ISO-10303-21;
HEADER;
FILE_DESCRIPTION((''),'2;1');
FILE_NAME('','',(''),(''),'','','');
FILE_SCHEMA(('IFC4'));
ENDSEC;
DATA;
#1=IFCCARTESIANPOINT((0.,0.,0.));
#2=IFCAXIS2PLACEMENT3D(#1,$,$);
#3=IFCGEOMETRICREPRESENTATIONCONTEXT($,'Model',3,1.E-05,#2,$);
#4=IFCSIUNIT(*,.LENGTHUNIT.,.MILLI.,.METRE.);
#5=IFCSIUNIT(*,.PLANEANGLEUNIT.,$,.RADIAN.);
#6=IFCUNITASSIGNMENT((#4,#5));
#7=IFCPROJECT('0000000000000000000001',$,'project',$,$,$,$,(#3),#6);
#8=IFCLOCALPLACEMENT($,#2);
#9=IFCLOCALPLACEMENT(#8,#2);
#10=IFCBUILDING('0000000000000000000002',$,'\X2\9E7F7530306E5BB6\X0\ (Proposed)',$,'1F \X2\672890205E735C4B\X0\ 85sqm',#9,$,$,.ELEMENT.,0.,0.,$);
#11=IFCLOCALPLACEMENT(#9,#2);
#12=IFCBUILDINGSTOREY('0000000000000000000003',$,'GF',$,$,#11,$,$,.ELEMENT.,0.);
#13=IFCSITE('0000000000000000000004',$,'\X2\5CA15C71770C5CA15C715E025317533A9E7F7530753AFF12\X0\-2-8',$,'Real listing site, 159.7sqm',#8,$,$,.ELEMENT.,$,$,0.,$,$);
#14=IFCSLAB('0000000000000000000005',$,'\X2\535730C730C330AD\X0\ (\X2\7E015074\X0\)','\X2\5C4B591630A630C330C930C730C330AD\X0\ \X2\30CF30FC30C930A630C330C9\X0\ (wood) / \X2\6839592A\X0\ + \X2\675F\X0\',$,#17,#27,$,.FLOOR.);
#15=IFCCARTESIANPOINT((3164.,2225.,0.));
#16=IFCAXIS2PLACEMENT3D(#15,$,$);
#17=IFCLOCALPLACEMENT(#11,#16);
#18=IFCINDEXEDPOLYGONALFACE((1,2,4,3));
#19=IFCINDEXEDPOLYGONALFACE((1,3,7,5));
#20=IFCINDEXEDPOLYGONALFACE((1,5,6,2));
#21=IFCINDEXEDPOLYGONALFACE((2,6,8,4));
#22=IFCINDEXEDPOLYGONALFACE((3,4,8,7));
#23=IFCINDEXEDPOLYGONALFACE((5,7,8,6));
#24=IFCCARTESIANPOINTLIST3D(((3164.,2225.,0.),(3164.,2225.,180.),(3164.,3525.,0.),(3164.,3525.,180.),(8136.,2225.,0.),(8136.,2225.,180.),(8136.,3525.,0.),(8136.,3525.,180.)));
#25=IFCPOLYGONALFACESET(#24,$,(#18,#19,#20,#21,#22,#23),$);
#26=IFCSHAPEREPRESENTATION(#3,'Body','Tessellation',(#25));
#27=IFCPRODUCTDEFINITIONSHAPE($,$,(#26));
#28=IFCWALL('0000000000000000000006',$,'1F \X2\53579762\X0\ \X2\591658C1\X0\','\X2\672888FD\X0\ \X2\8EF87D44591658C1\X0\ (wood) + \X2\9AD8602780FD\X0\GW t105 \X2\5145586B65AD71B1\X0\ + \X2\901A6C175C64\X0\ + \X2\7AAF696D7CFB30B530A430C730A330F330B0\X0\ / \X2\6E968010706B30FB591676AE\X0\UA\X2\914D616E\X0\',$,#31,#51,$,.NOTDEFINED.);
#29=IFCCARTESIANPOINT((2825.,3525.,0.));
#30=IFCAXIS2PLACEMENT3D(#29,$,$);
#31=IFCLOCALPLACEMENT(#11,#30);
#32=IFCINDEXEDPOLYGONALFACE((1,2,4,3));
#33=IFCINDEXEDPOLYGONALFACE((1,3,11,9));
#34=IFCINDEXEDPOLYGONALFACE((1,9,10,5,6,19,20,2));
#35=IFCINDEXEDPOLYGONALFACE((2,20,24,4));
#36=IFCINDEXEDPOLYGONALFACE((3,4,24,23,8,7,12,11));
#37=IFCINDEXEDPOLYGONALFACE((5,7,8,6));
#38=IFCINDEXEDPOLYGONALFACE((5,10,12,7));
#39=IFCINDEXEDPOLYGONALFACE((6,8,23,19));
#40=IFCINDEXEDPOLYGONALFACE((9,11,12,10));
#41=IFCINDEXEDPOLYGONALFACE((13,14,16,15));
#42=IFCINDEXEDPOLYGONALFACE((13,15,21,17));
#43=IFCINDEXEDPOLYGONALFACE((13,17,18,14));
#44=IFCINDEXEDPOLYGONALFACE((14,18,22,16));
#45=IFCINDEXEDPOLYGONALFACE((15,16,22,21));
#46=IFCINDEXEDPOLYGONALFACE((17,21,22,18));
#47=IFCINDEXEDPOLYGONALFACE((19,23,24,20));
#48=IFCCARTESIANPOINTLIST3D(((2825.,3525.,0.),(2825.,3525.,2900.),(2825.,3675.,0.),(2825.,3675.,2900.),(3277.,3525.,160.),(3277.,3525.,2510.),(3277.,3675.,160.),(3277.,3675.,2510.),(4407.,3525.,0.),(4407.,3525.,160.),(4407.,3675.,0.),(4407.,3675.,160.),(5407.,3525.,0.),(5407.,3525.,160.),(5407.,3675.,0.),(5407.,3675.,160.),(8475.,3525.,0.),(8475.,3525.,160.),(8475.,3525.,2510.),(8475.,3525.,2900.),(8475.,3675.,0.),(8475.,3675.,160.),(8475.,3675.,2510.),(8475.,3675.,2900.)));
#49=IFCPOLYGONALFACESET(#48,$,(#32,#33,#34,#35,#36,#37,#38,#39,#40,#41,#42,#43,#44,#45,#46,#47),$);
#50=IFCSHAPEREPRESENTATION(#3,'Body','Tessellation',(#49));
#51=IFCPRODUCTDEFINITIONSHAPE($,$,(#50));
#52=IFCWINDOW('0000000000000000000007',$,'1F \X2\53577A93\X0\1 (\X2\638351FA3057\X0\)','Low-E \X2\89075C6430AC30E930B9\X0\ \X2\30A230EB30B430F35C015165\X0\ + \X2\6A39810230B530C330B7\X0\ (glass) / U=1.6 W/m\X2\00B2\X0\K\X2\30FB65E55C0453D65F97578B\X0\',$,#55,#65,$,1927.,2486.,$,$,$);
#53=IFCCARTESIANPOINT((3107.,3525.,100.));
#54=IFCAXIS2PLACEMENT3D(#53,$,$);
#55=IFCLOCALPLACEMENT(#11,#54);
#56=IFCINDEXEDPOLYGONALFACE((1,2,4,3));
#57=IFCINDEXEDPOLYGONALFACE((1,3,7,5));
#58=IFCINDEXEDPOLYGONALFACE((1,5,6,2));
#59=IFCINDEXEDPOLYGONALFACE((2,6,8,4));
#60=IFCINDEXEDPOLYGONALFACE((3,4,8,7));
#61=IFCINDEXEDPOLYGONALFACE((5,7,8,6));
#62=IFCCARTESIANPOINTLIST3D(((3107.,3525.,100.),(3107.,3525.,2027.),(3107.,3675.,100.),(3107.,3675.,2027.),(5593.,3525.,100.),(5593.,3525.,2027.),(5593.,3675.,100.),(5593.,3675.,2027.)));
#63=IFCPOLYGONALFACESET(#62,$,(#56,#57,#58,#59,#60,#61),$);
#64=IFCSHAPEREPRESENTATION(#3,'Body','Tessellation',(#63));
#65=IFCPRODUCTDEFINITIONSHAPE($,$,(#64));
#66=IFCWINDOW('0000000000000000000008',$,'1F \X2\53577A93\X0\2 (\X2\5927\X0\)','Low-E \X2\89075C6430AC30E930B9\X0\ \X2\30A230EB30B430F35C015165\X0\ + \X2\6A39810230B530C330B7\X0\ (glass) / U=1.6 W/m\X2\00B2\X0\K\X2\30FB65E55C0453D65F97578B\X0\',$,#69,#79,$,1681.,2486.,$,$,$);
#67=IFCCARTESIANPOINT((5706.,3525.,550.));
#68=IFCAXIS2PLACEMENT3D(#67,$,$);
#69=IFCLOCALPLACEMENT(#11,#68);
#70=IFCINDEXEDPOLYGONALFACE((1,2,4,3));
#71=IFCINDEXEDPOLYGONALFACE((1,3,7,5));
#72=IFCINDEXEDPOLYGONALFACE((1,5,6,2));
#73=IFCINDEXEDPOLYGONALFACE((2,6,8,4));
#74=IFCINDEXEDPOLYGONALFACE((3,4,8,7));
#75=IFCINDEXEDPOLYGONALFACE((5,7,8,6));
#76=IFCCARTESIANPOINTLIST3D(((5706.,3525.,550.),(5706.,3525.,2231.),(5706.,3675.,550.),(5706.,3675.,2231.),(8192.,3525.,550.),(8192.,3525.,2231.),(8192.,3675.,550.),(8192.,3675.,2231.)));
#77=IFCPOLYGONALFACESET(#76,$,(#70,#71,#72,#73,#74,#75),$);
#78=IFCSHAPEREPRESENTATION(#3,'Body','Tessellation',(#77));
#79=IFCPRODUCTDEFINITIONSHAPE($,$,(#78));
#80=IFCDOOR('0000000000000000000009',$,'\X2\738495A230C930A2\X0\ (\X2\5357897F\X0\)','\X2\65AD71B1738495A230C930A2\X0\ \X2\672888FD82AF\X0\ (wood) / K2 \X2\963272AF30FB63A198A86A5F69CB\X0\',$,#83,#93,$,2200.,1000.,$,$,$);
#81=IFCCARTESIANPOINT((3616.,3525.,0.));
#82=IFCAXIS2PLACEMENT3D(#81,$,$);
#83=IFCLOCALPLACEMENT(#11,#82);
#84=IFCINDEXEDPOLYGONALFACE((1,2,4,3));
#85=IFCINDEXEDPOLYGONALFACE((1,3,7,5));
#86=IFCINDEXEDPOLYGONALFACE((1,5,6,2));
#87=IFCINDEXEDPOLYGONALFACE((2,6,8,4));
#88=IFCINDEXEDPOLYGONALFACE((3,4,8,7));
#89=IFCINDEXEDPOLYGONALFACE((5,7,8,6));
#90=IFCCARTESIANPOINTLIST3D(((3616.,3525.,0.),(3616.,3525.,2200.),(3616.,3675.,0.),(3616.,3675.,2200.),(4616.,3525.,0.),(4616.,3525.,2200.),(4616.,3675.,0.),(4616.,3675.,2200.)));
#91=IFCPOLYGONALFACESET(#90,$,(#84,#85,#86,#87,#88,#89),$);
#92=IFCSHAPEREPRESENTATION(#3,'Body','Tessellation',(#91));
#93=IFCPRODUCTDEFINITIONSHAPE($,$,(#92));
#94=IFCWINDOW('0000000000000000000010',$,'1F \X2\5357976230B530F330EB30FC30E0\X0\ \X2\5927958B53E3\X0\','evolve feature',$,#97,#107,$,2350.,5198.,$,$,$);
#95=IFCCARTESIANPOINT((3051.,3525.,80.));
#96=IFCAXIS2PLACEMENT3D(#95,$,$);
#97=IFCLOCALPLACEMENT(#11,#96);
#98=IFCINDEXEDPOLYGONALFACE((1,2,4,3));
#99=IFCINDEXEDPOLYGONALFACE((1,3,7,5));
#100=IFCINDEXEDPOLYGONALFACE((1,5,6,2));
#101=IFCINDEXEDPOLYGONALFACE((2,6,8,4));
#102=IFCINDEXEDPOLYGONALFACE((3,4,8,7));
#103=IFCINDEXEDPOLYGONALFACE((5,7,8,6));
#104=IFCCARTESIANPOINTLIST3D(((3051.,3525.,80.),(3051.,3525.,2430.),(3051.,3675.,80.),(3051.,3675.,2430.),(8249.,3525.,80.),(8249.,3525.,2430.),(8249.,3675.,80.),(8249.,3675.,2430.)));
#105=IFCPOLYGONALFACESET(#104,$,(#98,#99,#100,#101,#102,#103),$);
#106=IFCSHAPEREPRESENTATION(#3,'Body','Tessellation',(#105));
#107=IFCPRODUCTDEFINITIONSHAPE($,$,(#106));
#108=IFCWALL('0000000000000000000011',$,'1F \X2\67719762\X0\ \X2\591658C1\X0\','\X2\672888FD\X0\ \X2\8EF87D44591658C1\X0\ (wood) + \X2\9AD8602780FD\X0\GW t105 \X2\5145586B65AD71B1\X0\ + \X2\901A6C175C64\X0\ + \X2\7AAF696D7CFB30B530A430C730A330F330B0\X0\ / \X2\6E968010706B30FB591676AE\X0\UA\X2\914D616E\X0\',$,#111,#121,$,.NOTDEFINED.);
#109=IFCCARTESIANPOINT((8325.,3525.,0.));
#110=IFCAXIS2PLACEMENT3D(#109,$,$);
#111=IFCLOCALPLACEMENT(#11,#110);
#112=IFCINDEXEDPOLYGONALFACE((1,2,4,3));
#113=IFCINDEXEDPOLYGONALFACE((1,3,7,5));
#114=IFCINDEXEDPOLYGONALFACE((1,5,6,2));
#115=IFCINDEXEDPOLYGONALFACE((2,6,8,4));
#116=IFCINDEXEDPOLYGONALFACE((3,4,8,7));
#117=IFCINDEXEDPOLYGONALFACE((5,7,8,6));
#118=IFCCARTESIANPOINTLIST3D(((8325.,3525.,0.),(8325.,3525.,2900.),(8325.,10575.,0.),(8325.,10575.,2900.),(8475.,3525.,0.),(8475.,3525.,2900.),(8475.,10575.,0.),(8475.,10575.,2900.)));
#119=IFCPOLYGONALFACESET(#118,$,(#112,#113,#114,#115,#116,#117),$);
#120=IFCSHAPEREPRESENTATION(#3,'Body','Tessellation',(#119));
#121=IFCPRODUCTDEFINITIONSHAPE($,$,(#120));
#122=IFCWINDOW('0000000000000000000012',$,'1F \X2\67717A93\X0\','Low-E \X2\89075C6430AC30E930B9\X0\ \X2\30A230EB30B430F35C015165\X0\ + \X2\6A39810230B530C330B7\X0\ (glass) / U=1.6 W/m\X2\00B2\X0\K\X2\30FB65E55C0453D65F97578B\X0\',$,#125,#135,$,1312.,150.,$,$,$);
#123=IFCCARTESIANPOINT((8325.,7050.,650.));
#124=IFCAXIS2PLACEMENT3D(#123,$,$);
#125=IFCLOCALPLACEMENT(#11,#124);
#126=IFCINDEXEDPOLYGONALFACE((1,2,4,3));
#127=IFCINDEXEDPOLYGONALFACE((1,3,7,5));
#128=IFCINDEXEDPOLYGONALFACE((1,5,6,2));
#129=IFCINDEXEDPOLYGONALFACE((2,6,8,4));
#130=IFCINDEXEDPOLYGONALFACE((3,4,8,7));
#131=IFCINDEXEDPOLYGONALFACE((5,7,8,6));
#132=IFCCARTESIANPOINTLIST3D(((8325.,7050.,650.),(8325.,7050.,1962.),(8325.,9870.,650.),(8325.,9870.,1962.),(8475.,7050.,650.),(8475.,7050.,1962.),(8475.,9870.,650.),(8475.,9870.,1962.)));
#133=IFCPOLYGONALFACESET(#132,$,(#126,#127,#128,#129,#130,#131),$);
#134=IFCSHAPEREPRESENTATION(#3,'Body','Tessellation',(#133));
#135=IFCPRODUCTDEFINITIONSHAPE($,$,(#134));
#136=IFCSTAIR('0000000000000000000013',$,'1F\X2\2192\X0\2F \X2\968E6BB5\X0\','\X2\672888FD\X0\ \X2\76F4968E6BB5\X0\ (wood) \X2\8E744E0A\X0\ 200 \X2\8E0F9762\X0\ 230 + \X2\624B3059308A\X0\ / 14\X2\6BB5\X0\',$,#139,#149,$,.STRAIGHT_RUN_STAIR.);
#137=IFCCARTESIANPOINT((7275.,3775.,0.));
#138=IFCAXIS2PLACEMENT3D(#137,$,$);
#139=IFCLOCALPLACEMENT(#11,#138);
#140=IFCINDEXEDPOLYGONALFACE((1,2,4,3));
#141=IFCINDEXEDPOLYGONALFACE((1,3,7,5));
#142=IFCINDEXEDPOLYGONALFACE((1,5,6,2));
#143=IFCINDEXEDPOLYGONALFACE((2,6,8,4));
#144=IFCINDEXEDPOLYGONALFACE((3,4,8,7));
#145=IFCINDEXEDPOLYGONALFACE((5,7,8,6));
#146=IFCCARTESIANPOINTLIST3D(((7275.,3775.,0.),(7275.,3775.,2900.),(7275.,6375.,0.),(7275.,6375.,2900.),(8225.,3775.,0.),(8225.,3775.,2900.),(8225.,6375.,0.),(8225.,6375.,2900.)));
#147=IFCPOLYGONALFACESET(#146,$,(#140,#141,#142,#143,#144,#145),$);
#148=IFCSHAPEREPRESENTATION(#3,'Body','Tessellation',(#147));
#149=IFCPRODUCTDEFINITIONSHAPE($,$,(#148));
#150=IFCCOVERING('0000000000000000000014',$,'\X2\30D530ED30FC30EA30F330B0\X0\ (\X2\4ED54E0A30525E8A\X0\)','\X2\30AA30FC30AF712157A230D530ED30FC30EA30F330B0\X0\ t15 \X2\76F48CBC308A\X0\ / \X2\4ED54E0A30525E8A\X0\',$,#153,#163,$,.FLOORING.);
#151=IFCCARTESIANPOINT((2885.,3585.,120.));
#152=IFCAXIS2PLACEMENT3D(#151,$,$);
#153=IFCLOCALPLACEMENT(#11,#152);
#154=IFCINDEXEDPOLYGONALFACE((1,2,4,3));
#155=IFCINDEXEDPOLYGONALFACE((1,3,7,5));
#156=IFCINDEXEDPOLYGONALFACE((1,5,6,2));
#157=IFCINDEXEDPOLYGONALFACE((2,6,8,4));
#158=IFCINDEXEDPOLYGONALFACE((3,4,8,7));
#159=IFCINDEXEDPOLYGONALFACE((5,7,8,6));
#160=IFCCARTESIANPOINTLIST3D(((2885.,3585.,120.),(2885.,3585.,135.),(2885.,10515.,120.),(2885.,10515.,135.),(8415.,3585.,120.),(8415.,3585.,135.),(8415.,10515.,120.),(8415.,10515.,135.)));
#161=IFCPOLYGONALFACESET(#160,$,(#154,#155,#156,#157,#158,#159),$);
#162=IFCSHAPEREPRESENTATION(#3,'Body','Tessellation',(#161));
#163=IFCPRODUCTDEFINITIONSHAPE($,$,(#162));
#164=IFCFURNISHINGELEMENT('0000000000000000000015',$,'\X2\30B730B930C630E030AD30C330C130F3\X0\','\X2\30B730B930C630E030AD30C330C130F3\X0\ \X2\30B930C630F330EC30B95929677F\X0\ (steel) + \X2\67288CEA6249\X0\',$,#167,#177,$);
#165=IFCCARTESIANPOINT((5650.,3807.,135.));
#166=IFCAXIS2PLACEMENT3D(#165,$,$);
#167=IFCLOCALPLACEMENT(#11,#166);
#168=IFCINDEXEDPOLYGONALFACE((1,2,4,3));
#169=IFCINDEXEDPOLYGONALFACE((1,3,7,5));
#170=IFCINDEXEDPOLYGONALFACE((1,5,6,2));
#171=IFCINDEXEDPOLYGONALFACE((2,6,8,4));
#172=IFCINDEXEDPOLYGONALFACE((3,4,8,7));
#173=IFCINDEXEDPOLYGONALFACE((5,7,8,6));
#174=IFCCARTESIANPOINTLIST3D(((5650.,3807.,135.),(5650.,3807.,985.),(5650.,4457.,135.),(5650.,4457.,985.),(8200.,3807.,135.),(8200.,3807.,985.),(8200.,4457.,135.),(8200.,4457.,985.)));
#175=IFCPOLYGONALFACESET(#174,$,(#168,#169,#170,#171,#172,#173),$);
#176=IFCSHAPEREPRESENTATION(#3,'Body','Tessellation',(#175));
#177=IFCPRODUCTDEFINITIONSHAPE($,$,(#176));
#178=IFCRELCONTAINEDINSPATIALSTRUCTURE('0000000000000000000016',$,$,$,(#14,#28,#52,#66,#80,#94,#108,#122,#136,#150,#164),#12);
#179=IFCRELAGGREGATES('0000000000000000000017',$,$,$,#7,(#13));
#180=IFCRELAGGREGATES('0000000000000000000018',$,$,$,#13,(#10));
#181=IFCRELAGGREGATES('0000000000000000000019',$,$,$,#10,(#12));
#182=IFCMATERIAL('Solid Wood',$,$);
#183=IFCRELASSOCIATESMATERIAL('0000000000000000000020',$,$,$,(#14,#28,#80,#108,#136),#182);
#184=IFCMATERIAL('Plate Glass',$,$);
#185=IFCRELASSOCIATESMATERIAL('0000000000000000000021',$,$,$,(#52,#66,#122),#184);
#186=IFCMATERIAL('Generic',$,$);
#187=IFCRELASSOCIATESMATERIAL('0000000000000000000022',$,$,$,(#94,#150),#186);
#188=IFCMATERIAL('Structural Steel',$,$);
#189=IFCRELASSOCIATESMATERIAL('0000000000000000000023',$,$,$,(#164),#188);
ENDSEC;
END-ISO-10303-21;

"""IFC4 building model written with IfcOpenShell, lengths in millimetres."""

from ifc_helpers import new_model, si_unit, frame, frame_2d, origin, place, context, project, spatial, rectangle, extrude, material, element, fill, save


model = new_model("IFC4")

# Units and contexts
model_context = context("Model", 3, precision=1e-05, world=origin())
ifc_project = project(units=[si_unit("LENGTHUNIT", "METRE", prefix="MILLI"), si_unit("PLANEANGLEUNIT", "RADIAN")], contexts=[model_context])

# Site, building, storey
site_placement = place(None, origin())
site = spatial("IfcSite", under=ifc_project, at=site_placement, Name="岡山県岡山市北区鹿田町２-2-8", ObjectType="Real listing site, 159.7sqm", CompositionType="ELEMENT", RefElevation=0.0)
building_placement = place(site_placement, origin())
building = spatial("IfcBuilding", under=site, at=building_placement, Name="鹿田の家 (Proposed)", ObjectType="1F 木造平屋 85sqm", CompositionType="ELEMENT", ElevationOfRefHeight=0.0, ElevationOfTerrain=0.0)
storey_placement = place(building_placement, origin())
storey = spatial("IfcBuildingStorey", under=building, at=storey_placement, Name="GF", CompositionType="ELEMENT", Elevation=0.0)

# Slab
ifc_material_1 = material(Name="Solid Wood")
slab_1_placement = place(storey_placement, frame((3164.0, 2225.0, 0.0)))
element("IfcSlab", 1, at=slab_1_placement, inside=storey, material=ifc_material_1, Name="南デッキ (縁側)", Description="屋外ウッドデッキ ハードウッド (wood) / 根太 + 束", PredefinedType="FLOOR", context=model_context, shape_type="SweptSolid", body=[
    extrude(rectangle(XDim=4972.0, YDim=1300.0, at=frame_2d((2486.0, 650.0))), frame((3164.0, 2225.0, 0.0)), (0.0, 0.0, 1.0), 180.0),
])
ifc_material_2 = material(Name="Generic")

# Wall, openings, windows, door
wall_1_placement = place(storey_placement, frame((2825.0, 3525.0, 0.0)))
wall_1 = element("IfcWall", 2, at=wall_1_placement, inside=storey, material=ifc_material_1, Name="1F 南面 外壁", Description="木製 軸組外壁 (wood) + 高性能GW t105 充填断熱 + 通気層 + 窯業系サイディング / 準耐火・外皮UA配慮", PredefinedType="NOTDEFINED", context=model_context, shape_type="SweptSolid", body=[
    extrude(rectangle(XDim=5650.0, YDim=150.0, at=frame_2d((2825.0, 75.0))), frame((2825.0, 3525.0, 0.0)), (0.0, 0.0, 1.0), 2900.0),
])
opening_1_placement = place(storey_placement, frame((3107.0, 3525.0, 100.0)))
opening_1 = element("IfcOpeningElement", 3, at=opening_1_placement, cuts=wall_1, PredefinedType="NOTDEFINED", context=model_context, shape_type="SweptSolid", body=[
    extrude(rectangle(XDim=2486.0, YDim=150.0, at=frame_2d((1243.0, 75.0))), frame((3107.0, 3525.0, 100.0)), (0.0, 0.0, 1.0), 1927.0),
])
opening_2_placement = place(storey_placement, frame((5706.0, 3525.0, 550.0)))
opening_2 = element("IfcOpeningElement", 4, at=opening_2_placement, cuts=wall_1, PredefinedType="NOTDEFINED", context=model_context, shape_type="SweptSolid", body=[
    extrude(rectangle(XDim=2486.0, YDim=150.0, at=frame_2d((1243.0, 75.0))), frame((5706.0, 3525.0, 550.0)), (0.0, 0.0, 1.0), 1681.0),
])
opening_3_placement = place(storey_placement, frame((3616.0, 3525.0, 0.0)))
opening_3 = element("IfcOpeningElement", 5, at=opening_3_placement, cuts=wall_1, PredefinedType="NOTDEFINED", context=model_context, shape_type="SweptSolid", body=[
    extrude(rectangle(XDim=1000.0, YDim=150.0, at=frame_2d((500.0, 75.0))), frame((3616.0, 3525.0, 0.0)), (0.0, 0.0, 1.0), 2200.0),
])
opening_4_placement = place(storey_placement, frame((3051.0, 3525.0, 80.0)))
opening_4 = element("IfcOpeningElement", 6, at=opening_4_placement, cuts=wall_1, PredefinedType="NOTDEFINED", context=model_context, shape_type="SweptSolid", body=[
    extrude(rectangle(XDim=5198.0, YDim=150.0, at=frame_2d((2599.0, 75.0))), frame((3051.0, 3525.0, 80.0)), (0.0, 0.0, 1.0), 2350.0),
])
ifc_material_3 = material(Name="Plate Glass")
window_1_placement = place(storey_placement, frame((3107.0, 3525.0, 100.0)))
window_1 = element("IfcWindow", 7, at=window_1_placement, inside=storey, material=ifc_material_3, Name="1F 南窓1 (掃出し)", Description="Low-E 複層ガラス アルゴン封入 + 樹脂サッシ (glass) / U=1.6 W/m²K・日射取得型", OverallHeight=1927.0, OverallWidth=2486.0, context=model_context, shape_type="SweptSolid", body=[
    extrude(rectangle(XDim=2486.0, YDim=150.0, at=frame_2d((1243.0, 75.0))), frame((3107.0, 3525.0, 100.0)), (0.0, 0.0, 1.0), 1927.0),
])
fill(opening_1, window_1)
window_2_placement = place(storey_placement, frame((5706.0, 3525.0, 550.0)))
window_2 = element("IfcWindow", 8, at=window_2_placement, inside=storey, material=ifc_material_3, Name="1F 南窓2 (大)", Description="Low-E 複層ガラス アルゴン封入 + 樹脂サッシ (glass) / U=1.6 W/m²K・日射取得型", OverallHeight=1681.0, OverallWidth=2486.0, context=model_context, shape_type="SweptSolid", body=[
    extrude(rectangle(XDim=2486.0, YDim=150.0, at=frame_2d((1243.0, 75.0))), frame((5706.0, 3525.0, 550.0)), (0.0, 0.0, 1.0), 1681.0),
])
fill(opening_2, window_2)
door_placement = place(storey_placement, frame((3616.0, 3525.0, 0.0)))
door = element("IfcDoor", 9, at=door_placement, inside=storey, material=ifc_material_1, Name="玄関ドア (南西)", Description="断熱玄関ドア 木製芯 (wood) / K2 防犯・採風機構", OverallHeight=2200.0, OverallWidth=1000.0, context=model_context, shape_type="SweptSolid", body=[
    extrude(rectangle(XDim=1000.0, YDim=150.0, at=frame_2d((500.0, 75.0))), frame((3616.0, 3525.0, 0.0)), (0.0, 0.0, 1.0), 2200.0),
])
fill(opening_3, door)
window_3_placement = place(storey_placement, frame((3051.0, 3525.0, 80.0)))
window_3 = element("IfcWindow", 10, at=window_3_placement, inside=storey, material=ifc_material_2, Name="1F 南面サンルーム 大開口", Description="evolve feature", OverallHeight=2350.0, OverallWidth=5198.0, context=model_context, shape_type="SweptSolid", body=[
    extrude(rectangle(XDim=5198.0, YDim=150.0, at=frame_2d((2599.0, 75.0))), frame((3051.0, 3525.0, 80.0)), (0.0, 0.0, 1.0), 2350.0),
])
fill(opening_4, window_3)

# Wall, opening, window
wall_2_placement = place(storey_placement, frame((8325.0, 3525.0, 0.0)))
wall_2 = element("IfcWall", 11, at=wall_2_placement, inside=storey, material=ifc_material_1, Name="1F 東面 外壁", Description="木製 軸組外壁 (wood) + 高性能GW t105 充填断熱 + 通気層 + 窯業系サイディング / 準耐火・外皮UA配慮", PredefinedType="NOTDEFINED", context=model_context, shape_type="SweptSolid", body=[
    extrude(rectangle(XDim=150.0, YDim=7050.0, at=frame_2d((75.0, 3525.0))), frame((8325.0, 3525.0, 0.0)), (0.0, 0.0, 1.0), 2900.0),
])
opening_5_placement = place(storey_placement, frame((8325.0, 7050.0, 650.0)))
opening_5 = element("IfcOpeningElement", 12, at=opening_5_placement, cuts=wall_2, PredefinedType="NOTDEFINED", context=model_context, shape_type="SweptSolid", body=[
    extrude(rectangle(XDim=150.0, YDim=2820.0, at=frame_2d((75.0, 1410.0))), frame((8325.0, 7050.0, 650.0)), (0.0, 0.0, 1.0), 1312.0),
])
window_4_placement = place(storey_placement, frame((8325.0, 7050.0, 650.0)))
window_4 = element("IfcWindow", 13, at=window_4_placement, inside=storey, material=ifc_material_3, Name="1F 東窓", Description="Low-E 複層ガラス アルゴン封入 + 樹脂サッシ (glass) / U=1.6 W/m²K・日射取得型", OverallHeight=1312.0, OverallWidth=150.0, context=model_context, shape_type="SweptSolid", body=[
    extrude(rectangle(XDim=150.0, YDim=2820.0, at=frame_2d((75.0, 1410.0))), frame((8325.0, 7050.0, 650.0)), (0.0, 0.0, 1.0), 1312.0),
])
fill(opening_5, window_4)

# Stair
stair_placement = place(storey_placement, frame((7275.0, 3775.0, 0.0)))
element("IfcStair", 14, at=stair_placement, inside=storey, material=ifc_material_1, Name="1F→2F 階段", Description="木製 直階段 (wood) 蹴上 200 踏面 230 + 手すり / 14段", PredefinedType="STRAIGHT_RUN_STAIR", context=model_context, shape_type="SweptSolid", body=[
    extrude(rectangle(XDim=950.0, YDim=2600.0, at=frame_2d((475.0, 1300.0))), frame((7275.0, 3775.0, 0.0)), (0.0, 0.0, 1.0), 2900.0),
])

# Covering
covering_placement = place(storey_placement, frame((2885.0, 3585.0, 120.0)))
element("IfcCovering", 15, at=covering_placement, inside=storey, material=ifc_material_2, Name="フローリング (仕上げ床)", Description="オーク無垢フローリング t15 直貼り / 仕上げ床", PredefinedType="FLOORING", context=model_context, shape_type="SweptSolid", body=[
    extrude(rectangle(XDim=5530.0, YDim=6930.0, at=frame_2d((2765.0, 3465.0))), frame((2885.0, 3585.0, 120.0)), (0.0, 0.0, 1.0), 15.0),
])

# Furnishing element
ifc_material_4 = material(Name="Structural Steel")
furnishing_placement = place(storey_placement, frame((5650.0, 3807.0, 135.0)))
element("IfcFurnishingElement", 16, at=furnishing_placement, inside=storey, material=ifc_material_4, Name="システムキッチン", Description="システムキッチン ステンレス天板 (steel) + 木質扉", context=model_context, shape_type="SweptSolid", body=[
    extrude(rectangle(XDim=2550.0, YDim=650.0, at=frame_2d((1275.0, 325.0))), frame((5650.0, 3807.0, 135.0)), (0.0, 0.0, 1.0), 850.0),
])

save(model, "model.ifc")
